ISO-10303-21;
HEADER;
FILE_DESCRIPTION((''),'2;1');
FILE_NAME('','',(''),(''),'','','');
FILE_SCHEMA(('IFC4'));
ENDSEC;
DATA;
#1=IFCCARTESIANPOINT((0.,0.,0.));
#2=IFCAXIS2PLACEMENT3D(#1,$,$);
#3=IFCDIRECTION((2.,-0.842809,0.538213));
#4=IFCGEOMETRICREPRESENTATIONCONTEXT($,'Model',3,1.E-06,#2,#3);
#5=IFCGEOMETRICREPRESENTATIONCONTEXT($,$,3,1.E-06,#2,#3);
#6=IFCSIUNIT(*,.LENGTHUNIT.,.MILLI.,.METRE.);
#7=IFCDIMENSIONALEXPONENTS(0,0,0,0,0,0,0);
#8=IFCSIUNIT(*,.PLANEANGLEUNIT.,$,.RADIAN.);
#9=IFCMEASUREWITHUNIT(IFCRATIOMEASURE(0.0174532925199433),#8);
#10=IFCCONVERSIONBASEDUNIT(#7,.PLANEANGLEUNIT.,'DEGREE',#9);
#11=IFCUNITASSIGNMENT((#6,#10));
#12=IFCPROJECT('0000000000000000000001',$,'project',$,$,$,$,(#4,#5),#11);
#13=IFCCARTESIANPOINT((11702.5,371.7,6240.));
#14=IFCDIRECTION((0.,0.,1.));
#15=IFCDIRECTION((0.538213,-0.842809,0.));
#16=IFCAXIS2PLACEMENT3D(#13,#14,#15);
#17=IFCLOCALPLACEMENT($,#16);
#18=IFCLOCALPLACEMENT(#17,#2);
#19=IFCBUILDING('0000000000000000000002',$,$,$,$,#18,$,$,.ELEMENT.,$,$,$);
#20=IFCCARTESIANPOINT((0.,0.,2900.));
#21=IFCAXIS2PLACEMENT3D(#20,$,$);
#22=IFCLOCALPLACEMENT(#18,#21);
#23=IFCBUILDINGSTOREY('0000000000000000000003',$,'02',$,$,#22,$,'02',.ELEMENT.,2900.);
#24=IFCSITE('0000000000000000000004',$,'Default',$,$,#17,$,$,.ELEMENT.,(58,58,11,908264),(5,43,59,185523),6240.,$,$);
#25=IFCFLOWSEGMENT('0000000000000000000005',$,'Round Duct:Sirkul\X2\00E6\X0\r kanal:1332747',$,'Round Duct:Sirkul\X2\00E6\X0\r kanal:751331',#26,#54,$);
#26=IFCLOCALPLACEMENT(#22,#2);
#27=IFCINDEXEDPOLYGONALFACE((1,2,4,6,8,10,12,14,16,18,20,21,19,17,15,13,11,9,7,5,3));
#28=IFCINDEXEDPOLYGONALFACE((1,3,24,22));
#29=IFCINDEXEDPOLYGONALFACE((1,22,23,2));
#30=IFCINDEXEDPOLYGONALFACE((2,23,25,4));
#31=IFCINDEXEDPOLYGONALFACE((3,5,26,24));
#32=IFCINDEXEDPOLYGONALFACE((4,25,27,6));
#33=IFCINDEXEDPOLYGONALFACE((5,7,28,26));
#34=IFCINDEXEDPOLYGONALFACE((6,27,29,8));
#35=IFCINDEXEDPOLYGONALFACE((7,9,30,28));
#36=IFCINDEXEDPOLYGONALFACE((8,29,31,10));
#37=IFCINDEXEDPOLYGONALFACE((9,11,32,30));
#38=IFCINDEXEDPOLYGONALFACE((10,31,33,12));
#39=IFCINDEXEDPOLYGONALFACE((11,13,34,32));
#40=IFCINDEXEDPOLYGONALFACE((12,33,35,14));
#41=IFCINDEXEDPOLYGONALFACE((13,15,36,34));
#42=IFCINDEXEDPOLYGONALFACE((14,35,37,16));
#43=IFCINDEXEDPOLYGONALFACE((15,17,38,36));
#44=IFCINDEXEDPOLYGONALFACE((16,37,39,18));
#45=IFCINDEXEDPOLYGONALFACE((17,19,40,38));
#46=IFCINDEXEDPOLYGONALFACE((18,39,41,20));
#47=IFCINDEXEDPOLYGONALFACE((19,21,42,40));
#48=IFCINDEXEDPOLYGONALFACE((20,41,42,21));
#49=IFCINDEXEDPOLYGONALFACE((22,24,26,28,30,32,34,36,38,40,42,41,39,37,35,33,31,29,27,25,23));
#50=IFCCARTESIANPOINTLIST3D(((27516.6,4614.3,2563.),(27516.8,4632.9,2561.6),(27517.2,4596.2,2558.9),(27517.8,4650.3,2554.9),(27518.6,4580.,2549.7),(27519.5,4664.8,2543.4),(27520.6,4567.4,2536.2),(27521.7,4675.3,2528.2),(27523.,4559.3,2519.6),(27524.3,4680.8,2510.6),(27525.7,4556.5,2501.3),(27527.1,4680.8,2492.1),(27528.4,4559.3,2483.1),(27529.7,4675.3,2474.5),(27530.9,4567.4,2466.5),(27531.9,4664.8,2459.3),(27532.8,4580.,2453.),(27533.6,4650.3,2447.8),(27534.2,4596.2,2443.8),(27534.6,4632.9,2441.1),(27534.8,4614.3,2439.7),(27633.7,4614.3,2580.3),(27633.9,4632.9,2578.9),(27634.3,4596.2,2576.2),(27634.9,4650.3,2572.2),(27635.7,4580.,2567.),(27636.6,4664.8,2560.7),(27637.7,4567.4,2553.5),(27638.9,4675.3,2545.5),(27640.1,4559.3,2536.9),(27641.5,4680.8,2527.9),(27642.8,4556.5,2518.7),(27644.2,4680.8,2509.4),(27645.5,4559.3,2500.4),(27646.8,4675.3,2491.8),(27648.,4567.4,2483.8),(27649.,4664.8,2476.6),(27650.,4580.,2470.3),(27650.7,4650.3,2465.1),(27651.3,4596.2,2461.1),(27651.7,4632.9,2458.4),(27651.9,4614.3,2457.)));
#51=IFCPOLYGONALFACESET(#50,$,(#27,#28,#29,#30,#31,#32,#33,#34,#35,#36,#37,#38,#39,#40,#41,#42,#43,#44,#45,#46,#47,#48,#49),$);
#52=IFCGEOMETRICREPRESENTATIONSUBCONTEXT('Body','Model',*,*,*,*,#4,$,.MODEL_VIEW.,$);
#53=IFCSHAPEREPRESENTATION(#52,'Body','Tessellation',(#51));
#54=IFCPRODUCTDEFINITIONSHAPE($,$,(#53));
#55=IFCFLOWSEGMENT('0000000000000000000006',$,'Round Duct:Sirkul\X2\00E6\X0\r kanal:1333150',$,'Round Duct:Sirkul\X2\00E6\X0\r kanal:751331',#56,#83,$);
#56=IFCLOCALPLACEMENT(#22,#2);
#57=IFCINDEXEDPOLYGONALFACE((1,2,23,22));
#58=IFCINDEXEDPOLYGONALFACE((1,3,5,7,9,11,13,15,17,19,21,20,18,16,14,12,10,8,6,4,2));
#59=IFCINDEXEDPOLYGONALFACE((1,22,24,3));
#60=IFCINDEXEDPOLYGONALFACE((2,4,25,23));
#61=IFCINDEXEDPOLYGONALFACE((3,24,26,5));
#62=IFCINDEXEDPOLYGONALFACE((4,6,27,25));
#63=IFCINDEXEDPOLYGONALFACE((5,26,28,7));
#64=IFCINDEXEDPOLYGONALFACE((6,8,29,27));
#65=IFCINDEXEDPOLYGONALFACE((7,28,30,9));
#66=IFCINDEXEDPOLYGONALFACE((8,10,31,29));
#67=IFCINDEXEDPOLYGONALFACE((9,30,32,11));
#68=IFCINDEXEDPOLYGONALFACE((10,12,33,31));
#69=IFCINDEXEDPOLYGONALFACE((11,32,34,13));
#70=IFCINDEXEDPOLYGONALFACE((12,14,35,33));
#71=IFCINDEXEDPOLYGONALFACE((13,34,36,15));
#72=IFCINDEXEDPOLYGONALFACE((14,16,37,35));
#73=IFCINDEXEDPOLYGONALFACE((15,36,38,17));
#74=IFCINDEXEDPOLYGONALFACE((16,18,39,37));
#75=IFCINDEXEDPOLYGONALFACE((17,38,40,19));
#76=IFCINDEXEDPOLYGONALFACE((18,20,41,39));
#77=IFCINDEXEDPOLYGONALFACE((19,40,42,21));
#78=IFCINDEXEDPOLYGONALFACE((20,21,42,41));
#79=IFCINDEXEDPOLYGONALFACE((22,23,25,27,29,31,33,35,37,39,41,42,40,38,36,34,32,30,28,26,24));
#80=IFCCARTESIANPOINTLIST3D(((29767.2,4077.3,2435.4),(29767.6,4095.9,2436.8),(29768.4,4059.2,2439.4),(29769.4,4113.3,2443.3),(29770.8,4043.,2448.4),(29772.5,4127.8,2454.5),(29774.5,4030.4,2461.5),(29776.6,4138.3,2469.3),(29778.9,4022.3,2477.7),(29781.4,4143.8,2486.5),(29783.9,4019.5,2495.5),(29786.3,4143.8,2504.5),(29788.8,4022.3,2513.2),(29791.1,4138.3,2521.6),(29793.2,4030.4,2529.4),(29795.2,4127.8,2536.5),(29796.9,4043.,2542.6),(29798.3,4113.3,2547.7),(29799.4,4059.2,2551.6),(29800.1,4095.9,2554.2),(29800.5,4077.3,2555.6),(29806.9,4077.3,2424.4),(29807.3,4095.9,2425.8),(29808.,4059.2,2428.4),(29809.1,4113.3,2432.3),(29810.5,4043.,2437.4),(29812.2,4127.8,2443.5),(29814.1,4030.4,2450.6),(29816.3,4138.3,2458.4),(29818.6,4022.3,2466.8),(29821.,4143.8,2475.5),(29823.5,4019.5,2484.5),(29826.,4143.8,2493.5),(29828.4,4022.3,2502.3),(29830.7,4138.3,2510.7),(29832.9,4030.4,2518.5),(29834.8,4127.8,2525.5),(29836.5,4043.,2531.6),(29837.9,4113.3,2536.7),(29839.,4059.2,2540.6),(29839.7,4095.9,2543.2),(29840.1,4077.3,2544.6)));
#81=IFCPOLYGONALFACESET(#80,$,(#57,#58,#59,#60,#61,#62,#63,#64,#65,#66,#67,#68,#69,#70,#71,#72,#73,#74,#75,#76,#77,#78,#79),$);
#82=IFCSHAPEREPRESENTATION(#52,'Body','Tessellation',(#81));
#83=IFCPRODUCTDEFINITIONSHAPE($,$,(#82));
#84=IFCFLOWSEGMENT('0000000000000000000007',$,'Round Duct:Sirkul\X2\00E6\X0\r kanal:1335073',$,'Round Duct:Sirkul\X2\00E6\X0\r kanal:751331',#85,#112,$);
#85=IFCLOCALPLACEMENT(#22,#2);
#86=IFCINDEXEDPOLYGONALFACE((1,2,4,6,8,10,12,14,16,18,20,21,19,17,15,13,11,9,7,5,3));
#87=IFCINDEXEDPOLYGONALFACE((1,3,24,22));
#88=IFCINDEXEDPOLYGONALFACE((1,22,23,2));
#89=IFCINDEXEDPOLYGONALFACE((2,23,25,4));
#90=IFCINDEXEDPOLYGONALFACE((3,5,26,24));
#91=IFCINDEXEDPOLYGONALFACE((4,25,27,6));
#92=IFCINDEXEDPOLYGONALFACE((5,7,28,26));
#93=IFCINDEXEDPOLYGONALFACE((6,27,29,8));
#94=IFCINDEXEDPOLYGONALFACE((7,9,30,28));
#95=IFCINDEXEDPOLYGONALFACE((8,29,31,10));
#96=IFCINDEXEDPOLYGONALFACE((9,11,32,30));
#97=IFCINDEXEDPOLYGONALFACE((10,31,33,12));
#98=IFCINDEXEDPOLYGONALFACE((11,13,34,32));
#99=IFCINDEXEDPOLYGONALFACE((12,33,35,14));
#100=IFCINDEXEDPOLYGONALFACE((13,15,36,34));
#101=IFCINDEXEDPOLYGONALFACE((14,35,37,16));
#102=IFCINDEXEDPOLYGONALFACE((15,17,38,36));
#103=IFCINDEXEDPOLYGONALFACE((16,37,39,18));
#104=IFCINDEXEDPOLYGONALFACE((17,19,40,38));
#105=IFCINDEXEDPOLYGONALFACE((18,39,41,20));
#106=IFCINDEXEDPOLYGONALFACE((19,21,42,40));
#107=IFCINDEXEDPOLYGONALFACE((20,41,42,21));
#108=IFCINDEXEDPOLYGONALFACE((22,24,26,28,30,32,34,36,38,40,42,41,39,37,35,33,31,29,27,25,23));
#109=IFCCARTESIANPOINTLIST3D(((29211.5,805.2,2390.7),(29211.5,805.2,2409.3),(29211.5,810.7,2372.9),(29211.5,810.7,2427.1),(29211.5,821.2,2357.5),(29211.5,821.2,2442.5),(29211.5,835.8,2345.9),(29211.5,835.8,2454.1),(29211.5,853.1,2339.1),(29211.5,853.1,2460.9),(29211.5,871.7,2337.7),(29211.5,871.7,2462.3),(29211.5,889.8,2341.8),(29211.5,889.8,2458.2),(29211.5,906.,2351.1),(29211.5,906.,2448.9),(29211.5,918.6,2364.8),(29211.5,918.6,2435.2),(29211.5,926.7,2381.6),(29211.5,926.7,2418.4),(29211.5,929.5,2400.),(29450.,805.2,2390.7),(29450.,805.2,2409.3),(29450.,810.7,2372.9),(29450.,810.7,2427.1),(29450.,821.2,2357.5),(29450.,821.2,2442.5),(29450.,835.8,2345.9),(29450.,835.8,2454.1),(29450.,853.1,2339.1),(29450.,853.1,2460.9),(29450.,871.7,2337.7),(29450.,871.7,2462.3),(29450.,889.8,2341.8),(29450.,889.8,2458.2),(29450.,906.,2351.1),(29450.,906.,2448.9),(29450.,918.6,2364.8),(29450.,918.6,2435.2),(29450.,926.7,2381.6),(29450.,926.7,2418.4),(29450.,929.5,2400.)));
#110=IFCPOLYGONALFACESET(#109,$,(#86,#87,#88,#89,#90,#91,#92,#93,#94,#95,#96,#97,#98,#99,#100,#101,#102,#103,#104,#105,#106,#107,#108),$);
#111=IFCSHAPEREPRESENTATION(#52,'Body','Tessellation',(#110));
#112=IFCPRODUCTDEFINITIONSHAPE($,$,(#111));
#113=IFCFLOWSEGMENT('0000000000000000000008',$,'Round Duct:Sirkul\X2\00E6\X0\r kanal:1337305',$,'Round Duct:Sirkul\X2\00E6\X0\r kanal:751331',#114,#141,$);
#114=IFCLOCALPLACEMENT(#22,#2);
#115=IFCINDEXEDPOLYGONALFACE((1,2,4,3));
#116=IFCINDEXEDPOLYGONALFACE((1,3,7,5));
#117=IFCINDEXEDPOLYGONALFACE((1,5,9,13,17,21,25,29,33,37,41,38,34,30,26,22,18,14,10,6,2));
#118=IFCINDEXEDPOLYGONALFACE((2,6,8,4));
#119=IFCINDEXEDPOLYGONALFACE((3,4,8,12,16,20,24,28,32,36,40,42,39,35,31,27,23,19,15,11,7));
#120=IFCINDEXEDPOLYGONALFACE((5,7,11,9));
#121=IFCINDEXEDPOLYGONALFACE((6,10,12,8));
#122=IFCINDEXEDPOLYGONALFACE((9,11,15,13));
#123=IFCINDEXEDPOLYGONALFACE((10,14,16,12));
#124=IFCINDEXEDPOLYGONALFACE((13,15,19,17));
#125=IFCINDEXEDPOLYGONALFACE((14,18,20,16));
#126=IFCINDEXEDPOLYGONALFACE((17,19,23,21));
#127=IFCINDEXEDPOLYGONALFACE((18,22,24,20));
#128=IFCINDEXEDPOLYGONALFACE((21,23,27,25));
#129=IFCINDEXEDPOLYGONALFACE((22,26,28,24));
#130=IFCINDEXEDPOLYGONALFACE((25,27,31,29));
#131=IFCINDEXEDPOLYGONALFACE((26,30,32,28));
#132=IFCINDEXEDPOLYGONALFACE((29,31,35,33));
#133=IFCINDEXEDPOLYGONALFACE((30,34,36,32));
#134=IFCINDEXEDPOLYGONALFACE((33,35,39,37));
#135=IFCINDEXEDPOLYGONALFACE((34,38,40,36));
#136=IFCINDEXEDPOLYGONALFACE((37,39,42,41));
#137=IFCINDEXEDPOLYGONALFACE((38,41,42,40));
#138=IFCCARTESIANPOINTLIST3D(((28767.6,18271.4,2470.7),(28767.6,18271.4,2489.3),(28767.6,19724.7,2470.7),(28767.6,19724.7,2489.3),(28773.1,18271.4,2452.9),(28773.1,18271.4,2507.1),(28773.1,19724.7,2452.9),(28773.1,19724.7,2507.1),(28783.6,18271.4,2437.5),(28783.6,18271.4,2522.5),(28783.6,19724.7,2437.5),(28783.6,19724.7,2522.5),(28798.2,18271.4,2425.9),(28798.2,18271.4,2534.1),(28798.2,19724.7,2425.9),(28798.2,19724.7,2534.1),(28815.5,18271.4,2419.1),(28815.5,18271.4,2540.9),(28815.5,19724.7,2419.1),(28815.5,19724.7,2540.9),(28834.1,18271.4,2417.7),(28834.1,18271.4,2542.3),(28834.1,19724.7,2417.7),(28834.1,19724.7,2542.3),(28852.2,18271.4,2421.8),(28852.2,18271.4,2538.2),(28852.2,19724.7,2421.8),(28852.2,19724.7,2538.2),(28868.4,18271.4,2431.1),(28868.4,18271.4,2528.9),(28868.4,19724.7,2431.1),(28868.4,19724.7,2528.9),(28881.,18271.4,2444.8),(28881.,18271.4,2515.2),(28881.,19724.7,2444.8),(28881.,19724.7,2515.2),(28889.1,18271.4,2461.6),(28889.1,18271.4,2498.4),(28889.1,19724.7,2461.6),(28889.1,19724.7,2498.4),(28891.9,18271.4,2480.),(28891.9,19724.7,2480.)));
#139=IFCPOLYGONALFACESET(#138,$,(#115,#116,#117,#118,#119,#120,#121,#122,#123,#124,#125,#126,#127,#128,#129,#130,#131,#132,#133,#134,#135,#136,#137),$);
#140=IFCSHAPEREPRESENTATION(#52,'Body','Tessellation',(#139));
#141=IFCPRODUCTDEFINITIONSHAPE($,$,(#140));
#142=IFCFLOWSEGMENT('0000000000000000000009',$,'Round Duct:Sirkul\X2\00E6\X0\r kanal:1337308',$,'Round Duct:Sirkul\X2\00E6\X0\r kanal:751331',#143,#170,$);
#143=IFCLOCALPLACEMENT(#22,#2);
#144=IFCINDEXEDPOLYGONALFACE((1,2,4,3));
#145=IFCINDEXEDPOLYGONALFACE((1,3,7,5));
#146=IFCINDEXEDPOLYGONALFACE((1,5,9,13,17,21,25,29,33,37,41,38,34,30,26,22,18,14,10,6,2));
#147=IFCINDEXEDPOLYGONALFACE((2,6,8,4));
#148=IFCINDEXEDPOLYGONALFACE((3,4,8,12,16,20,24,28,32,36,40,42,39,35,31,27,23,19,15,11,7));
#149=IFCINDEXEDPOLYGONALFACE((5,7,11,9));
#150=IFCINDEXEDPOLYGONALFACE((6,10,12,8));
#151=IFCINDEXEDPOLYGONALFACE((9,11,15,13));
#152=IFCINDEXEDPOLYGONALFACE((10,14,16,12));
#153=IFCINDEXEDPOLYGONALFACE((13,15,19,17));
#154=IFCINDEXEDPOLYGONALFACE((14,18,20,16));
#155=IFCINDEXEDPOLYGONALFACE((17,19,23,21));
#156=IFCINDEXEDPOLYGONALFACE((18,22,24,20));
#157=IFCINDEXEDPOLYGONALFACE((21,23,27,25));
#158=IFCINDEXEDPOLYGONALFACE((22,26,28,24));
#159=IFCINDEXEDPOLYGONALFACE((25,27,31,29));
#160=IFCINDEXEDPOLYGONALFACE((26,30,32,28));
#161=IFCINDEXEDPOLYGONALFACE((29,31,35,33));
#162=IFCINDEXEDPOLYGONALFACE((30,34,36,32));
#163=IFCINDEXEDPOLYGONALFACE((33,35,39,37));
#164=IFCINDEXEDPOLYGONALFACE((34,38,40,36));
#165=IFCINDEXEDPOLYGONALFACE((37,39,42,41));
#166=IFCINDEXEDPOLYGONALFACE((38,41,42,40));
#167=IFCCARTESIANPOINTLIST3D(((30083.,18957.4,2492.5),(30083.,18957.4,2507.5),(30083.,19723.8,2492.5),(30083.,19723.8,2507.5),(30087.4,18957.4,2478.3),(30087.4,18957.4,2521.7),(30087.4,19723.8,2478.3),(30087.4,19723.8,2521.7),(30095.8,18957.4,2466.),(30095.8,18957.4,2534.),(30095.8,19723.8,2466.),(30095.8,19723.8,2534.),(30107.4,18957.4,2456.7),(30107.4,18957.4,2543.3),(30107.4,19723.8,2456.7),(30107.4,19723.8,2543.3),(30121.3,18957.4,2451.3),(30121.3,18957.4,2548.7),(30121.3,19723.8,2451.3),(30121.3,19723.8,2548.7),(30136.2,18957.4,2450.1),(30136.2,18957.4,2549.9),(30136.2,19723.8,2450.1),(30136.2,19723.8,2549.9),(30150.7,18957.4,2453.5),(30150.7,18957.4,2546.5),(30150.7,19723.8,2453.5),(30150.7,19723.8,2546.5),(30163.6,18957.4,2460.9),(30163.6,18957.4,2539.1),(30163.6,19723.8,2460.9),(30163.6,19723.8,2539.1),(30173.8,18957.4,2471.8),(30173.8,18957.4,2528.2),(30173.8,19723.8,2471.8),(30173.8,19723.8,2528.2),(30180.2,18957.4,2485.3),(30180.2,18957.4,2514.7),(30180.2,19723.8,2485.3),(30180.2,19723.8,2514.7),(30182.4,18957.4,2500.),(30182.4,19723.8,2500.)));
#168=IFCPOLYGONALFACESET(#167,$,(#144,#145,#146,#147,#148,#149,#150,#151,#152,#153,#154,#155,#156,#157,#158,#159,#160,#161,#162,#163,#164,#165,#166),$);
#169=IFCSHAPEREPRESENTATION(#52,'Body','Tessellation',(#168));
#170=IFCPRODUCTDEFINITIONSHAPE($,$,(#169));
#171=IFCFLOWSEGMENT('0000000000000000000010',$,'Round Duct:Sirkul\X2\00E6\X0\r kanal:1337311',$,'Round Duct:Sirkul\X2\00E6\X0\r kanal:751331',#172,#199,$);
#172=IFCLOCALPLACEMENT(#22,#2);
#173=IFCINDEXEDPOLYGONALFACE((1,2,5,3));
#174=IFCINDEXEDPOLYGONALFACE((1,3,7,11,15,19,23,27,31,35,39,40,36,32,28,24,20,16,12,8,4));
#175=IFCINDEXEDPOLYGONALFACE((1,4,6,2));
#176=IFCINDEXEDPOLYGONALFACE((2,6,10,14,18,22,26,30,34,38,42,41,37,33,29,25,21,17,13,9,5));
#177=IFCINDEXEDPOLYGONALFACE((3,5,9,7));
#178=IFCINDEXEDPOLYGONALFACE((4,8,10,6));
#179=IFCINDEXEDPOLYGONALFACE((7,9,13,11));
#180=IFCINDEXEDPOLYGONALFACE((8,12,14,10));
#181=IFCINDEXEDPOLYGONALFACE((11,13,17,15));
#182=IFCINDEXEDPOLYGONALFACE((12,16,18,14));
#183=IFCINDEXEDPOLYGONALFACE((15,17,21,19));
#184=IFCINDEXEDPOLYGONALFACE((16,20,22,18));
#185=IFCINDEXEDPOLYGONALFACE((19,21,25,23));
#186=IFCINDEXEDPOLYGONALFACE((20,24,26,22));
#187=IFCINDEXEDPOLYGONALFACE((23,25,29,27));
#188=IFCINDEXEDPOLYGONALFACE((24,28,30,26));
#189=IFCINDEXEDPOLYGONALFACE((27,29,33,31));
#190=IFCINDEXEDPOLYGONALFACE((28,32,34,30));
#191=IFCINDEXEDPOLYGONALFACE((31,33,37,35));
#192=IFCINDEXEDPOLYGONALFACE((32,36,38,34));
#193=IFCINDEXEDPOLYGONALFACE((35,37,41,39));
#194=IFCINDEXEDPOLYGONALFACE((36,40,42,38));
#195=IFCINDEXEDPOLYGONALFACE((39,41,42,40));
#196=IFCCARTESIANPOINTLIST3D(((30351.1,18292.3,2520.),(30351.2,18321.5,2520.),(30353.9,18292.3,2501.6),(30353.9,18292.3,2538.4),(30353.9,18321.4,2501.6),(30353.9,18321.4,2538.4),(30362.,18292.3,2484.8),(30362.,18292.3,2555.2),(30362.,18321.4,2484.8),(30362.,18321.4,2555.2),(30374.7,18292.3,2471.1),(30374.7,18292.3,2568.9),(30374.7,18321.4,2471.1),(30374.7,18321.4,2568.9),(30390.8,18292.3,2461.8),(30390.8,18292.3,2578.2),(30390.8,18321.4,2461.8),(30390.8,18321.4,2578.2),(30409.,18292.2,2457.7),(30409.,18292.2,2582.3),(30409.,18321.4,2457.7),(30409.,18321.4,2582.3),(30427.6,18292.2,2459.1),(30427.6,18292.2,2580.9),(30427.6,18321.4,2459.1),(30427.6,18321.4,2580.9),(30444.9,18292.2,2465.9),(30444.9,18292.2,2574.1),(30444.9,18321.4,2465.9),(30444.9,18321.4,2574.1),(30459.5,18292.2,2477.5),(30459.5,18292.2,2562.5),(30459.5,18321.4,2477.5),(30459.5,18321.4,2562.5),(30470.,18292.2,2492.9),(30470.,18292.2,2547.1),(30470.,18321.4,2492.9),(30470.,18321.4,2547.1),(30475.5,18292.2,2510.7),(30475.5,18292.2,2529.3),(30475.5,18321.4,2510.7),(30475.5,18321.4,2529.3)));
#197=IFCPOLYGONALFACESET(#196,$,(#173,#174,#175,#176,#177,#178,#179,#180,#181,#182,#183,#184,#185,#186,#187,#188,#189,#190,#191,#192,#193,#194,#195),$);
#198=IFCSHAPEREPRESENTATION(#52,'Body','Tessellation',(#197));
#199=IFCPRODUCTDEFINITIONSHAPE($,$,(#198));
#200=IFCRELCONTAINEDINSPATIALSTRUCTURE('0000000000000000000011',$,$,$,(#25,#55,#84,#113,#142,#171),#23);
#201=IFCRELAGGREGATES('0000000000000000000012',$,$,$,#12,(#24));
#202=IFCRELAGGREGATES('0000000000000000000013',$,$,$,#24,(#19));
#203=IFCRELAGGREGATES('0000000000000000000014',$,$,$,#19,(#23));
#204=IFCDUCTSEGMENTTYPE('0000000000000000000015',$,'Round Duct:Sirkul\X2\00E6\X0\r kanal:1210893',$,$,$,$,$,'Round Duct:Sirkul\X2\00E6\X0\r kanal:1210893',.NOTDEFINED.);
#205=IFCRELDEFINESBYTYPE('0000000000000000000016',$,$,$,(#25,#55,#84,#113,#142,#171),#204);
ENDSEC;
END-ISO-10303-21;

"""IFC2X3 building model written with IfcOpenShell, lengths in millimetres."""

from ifc_helpers import new_model, entity, si_unit, converted_unit, direction, frame, frame_2d, origin, origin_2d_with_axis, place, context, subcontext, project, spatial, circle, extrude, type_object, element, save


model = new_model("IFC2X3")

# Units and contexts
model_context = context("Model", 3, precision=1e-06, world=origin(), true_north=direction((2.0, -0.842809, 0.538213)))
context_of_model = context(None, 3, precision=1e-06, world=origin(), true_north=direction((2.0, -0.842809, 0.538213)))
body_context = subcontext(model_context, "Body", "Model", "MODEL_VIEW")
ifc_project = project(units=[si_unit("LENGTHUNIT", "METRE", prefix="MILLI"), converted_unit("PLANEANGLEUNIT", "DEGREE", entity("IfcRatioMeasure", 0.0174532925199433), si_unit("PLANEANGLEUNIT", "RADIAN"), dimensions=[0, 0, 0, 0, 0, 0, 0])], contexts=[model_context, context_of_model])

# Site, building, storey
site_placement = place(None, frame((11702.5, 371.7, 6240.0), z_axis=(0.0, 0.0, 1.0), x_axis=(0.538213, -0.842809, 0.0)))
site = spatial("IfcSite", under=ifc_project, at=site_placement, Name="Default", CompositionType="ELEMENT", RefLatitude=(58, 58, 11, 908264), RefLongitude=(5, 43, 59, 185523), RefElevation=6240.0)
building_placement = place(site_placement, origin())
building = spatial("IfcBuilding", under=site, at=building_placement, CompositionType="ELEMENT")
storey_placement = place(building_placement, frame((0.0, 0.0, 2900.0)))
storey = spatial("IfcBuildingStorey", under=building, at=storey_placement, Name="02", LongName="02", CompositionType="ELEMENT", Elevation=2900.0)

# Flow segments
duct_segment_type_1 = type_object("IfcDuctSegmentType", Name="Round Duct:Sirkulær kanal:1210893", ElementType="Round Duct:Sirkulær kanal:1210893", PredefinedType="NOTDEFINED")
flow_segment_1_placement = place(storey_placement, origin())
element("IfcFlowSegment", 1, at=flow_segment_1_placement, inside=storey, type_object=duct_segment_type_1, Name="Round Duct:Sirkulær kanal:1332747", ObjectType="Round Duct:Sirkulær kanal:751331", context=body_context, shape_type="SweptSolid", body=[
    extrude(circle(Radius=62.5, at=frame_2d((0.0, 0.0), x_axis=(1.0, 0.0))), frame((27525.7, 4619.0, 2501.3), z_axis=(0.98925, 0.0, 0.146233), x_axis=(0.0, -1.0, 0.0)), (0.0, 0.0, 1.0), 118.4),
])
flow_segment_2_placement = place(storey_placement, origin())
element("IfcFlowSegment", 2, at=flow_segment_2_placement, inside=storey, type_object=duct_segment_type_1, Name="Round Duct:Sirkulær kanal:1333150", ObjectType="Round Duct:Sirkulær kanal:751331", context=body_context, shape_type="SweptSolid", body=[
    extrude(circle(Radius=62.5, at=frame_2d((0.0, 0.0), x_axis=(1.0, 0.0))), frame((29823.5, 4082.0, 2484.5), z_axis=(-0.963847, 0.0, 0.266455), x_axis=(0.0, -1.0, 0.0)), (0.0, 0.0, 1.0), 41.1),
])
flow_segment_3_placement = place(storey_placement, origin())
element("IfcFlowSegment", 3, at=flow_segment_3_placement, inside=storey, type_object=duct_segment_type_1, Name="Round Duct:Sirkulær kanal:1335073", ObjectType="Round Duct:Sirkulær kanal:751331", context=body_context, shape_type="SweptSolid", body=[
    extrude(circle(Radius=62.5, at=frame_2d((0.0, 0.0), x_axis=(1.0, 0.0))), frame((29211.5, 867.0, 2400.0), z_axis=(1.0, 0.0, 0.0), x_axis=(0.0, 1.0, 0.0)), (0.0, 0.0, 1.0), 238.5),
])
flow_segment_4_placement = place(storey_placement, origin())
element("IfcFlowSegment", 4, at=flow_segment_4_placement, inside=storey, type_object=duct_segment_type_1, Name="Round Duct:Sirkulær kanal:1337305", ObjectType="Round Duct:Sirkulær kanal:751331", context=body_context, shape_type="SweptSolid", body=[
    extrude(circle(Radius=62.5, at=origin_2d_with_axis()), frame((28829.4, 18271.4, 2480.0), z_axis=(0.0, 1.0, 0.0), x_axis=(1.0, 0.0, 0.0)), (0.0, 0.0, 1.0), 1453.3),
])
flow_segment_5_placement = place(storey_placement, origin())
element("IfcFlowSegment", 5, at=flow_segment_5_placement, inside=storey, type_object=duct_segment_type_1, Name="Round Duct:Sirkulær kanal:1337308", ObjectType="Round Duct:Sirkulær kanal:751331", context=body_context, shape_type="SweptSolid", body=[
    extrude(circle(Radius=50.0, at=origin_2d_with_axis()), frame((30132.4, 18957.4, 2500.0), z_axis=(0.0, 1.0, 0.0), x_axis=(1.0, 0.0, 0.0)), (0.0, 0.0, 1.0), 766.5),
])
flow_segment_6_placement = place(storey_placement, origin())
element("IfcFlowSegment", 6, at=flow_segment_6_placement, inside=storey, type_object=duct_segment_type_1, Name="Round Duct:Sirkulær kanal:1337311", ObjectType="Round Duct:Sirkulær kanal:751331", context=body_context, shape_type="SweptSolid", body=[
    extrude(circle(Radius=62.5, at=origin_2d_with_axis()), frame((30413.6, 18292.2, 2520.0), z_axis=(0.000626, 1.0, 0.0), x_axis=(-1.0, 0.000626, 0.0)), (0.0, 0.0, 1.0), 29.2),
])

save(model, "model.ifc")
